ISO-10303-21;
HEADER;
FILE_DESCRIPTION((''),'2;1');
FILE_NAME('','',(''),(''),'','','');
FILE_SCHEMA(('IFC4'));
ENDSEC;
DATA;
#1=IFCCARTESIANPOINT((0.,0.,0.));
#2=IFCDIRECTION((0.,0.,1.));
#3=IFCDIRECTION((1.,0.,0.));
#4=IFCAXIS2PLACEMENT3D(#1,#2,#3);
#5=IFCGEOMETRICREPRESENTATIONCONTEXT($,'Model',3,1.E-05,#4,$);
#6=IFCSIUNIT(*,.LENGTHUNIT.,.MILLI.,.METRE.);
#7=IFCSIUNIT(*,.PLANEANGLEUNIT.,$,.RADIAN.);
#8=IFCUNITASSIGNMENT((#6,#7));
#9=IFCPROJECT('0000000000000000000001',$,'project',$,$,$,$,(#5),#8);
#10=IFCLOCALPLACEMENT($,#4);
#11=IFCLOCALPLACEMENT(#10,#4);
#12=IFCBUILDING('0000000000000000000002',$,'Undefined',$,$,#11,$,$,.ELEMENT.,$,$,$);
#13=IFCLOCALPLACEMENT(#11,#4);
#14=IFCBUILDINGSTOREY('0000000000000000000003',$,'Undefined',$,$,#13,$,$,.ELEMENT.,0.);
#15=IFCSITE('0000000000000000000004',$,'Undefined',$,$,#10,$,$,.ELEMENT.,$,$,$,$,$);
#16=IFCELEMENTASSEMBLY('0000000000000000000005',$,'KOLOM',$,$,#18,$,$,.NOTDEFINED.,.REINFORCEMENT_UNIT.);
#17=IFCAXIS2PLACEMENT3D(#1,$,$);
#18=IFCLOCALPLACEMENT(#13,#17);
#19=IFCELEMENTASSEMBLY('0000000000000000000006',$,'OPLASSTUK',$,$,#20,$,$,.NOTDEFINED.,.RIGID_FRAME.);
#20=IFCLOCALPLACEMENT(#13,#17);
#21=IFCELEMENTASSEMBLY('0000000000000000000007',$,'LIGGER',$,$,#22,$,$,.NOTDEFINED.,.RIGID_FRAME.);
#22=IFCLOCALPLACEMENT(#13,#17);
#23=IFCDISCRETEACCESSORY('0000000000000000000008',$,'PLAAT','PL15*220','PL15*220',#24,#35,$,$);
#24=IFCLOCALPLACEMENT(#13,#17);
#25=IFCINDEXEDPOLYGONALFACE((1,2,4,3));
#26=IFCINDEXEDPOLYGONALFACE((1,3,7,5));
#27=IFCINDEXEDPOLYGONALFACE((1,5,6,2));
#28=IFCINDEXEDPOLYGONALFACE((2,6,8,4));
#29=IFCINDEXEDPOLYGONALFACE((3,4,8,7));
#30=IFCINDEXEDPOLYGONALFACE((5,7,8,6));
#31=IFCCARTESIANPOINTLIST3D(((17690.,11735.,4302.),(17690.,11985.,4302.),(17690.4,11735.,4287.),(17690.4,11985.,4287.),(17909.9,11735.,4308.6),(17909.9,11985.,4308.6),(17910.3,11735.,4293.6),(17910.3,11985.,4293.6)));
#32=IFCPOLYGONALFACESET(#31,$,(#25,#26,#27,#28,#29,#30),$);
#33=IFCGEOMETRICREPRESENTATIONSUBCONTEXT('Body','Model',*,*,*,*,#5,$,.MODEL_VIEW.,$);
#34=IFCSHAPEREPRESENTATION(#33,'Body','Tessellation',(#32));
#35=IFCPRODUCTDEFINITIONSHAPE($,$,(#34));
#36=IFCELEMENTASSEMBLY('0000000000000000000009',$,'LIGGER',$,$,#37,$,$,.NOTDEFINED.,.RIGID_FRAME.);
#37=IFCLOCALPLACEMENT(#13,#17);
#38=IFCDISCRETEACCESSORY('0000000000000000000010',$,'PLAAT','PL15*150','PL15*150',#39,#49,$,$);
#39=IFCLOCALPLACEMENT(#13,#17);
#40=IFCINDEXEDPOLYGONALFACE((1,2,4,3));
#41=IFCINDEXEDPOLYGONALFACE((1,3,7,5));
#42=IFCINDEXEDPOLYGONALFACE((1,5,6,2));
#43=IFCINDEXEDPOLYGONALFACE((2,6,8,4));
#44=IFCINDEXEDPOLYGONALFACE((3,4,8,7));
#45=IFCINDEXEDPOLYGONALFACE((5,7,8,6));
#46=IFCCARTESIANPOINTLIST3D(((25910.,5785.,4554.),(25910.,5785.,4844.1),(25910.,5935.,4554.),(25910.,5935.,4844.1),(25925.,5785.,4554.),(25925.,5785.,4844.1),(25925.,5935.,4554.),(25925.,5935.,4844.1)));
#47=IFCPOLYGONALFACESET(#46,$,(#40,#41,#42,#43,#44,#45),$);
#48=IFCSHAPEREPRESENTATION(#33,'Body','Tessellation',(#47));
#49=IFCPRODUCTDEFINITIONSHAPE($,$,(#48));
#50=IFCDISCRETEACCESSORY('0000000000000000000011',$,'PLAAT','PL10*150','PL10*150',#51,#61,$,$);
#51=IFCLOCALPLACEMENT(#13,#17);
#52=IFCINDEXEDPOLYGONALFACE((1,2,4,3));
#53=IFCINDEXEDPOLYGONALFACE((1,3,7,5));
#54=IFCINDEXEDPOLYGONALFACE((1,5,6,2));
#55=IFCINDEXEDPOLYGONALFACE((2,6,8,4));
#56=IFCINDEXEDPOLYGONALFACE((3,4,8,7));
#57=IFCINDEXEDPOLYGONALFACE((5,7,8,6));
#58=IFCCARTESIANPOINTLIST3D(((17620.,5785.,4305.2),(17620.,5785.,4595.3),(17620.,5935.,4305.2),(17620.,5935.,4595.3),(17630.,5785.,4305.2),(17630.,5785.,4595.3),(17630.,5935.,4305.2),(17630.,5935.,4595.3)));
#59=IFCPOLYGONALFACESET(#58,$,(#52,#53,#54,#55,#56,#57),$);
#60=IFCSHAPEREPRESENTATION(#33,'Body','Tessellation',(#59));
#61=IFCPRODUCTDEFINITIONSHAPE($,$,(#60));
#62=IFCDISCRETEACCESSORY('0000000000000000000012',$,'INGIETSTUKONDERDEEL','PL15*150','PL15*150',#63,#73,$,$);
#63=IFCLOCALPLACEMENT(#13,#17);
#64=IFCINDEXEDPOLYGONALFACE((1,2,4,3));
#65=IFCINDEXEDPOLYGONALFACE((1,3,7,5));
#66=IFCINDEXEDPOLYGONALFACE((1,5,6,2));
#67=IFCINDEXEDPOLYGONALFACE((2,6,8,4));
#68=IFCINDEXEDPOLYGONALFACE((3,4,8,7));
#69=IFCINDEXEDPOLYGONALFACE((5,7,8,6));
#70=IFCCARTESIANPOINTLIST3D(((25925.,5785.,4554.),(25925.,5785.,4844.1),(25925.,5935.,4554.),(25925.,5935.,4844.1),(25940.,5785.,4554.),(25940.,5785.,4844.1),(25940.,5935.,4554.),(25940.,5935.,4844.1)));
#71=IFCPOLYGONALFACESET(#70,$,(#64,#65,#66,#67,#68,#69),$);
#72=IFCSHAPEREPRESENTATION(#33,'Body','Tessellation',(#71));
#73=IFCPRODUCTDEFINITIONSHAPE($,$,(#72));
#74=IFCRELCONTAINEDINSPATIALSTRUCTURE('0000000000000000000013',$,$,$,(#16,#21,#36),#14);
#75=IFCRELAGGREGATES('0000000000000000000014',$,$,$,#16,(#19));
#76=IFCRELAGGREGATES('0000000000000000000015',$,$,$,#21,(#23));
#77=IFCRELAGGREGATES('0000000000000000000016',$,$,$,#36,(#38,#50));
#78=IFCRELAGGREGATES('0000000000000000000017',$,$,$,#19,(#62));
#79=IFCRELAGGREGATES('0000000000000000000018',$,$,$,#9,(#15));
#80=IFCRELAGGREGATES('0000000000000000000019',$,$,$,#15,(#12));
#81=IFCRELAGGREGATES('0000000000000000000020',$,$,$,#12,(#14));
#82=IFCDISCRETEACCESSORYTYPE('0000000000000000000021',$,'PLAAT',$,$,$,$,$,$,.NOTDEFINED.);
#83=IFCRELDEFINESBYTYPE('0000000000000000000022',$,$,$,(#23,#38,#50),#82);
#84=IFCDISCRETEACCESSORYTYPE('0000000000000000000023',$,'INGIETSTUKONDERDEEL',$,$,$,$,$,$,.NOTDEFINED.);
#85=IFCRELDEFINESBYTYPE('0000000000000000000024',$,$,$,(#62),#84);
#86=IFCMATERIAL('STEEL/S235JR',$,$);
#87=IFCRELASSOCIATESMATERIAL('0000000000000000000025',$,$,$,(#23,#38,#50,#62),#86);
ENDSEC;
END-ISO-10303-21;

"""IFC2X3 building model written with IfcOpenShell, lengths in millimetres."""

from ifc_helpers import new_model, si_unit, frame, frame_2d, origin_with_axes, place, context, subcontext, project, spatial, rectangle, extrude, material, type_object, element, aggregate, save


model = new_model("IFC2X3")

# Units and contexts
model_context = context("Model", 3, precision=1e-05, world=origin_with_axes())
body_context = subcontext(model_context, "Body", "Model", "MODEL_VIEW")
ifc_project = project(units=[si_unit("LENGTHUNIT", "METRE", prefix="MILLI"), si_unit("PLANEANGLEUNIT", "RADIAN")], contexts=[model_context])

# Site, building, storey
site_placement = place(None, origin_with_axes())
site = spatial("IfcSite", under=ifc_project, at=site_placement, Name="Undefined", CompositionType="ELEMENT")
building_placement = place(site_placement, origin_with_axes())
building = spatial("IfcBuilding", under=site, at=building_placement, Name="Undefined", CompositionType="ELEMENT")
storey_placement = place(building_placement, origin_with_axes())
storey = spatial("IfcBuildingStorey", under=building, at=storey_placement, Name="Undefined", CompositionType="ELEMENT", Elevation=0.0)

# Shared definitions
ifc_material_1 = material(Name="STEEL/S235JR")

# Element assemblies
assembly_1_placement = place(storey_placement, origin_with_axes())
assembly_1 = element("IfcElementAssembly", 1, at=assembly_1_placement, inside=storey, Name="KOLOM", AssemblyPlace="NOTDEFINED", PredefinedType="REINFORCEMENT_UNIT")
assembly_2_placement = place(assembly_1_placement, origin_with_axes())
assembly_2 = element("IfcElementAssembly", 2, at=assembly_2_placement, Name="OPLASSTUK", AssemblyPlace="NOTDEFINED", PredefinedType="RIGID_FRAME")
aggregate(assembly_1, [assembly_2])

# Element assembly, discrete accessory
assembly_3_placement = place(storey_placement, origin_with_axes())
assembly_3 = element("IfcElementAssembly", 3, at=assembly_3_placement, inside=storey, Name="LIGGER", AssemblyPlace="NOTDEFINED", PredefinedType="RIGID_FRAME")
discrete_accessory_type_1 = type_object("IfcDiscreteAccessoryType", Name="PLAAT")
discrete_accessory_1_placement = place(assembly_3_placement, frame((17800.1, 11735.0, 4297.8), z_axis=(-0.99955, 0.0, -0.029987), x_axis=(0.0, 1.0, 0.0)))
discrete_accessory_1 = element("IfcDiscreteAccessory", 4, at=discrete_accessory_1_placement, type_object=discrete_accessory_type_1, material=ifc_material_1, Name="PLAAT", Description="PL15*220", ObjectType="PL15*220", context=body_context, shape_type="SweptSolid", body=[
    extrude(rectangle(XDim=15.0, YDim=220.0, at=frame_2d((0.0, 0.0), x_axis=(1.0, 0.0))), frame((250.0, 0.0, 0.0), z_axis=(-1.0, 0.0, 0.0), x_axis=(0.0, -1.0, 0.0)), (0.0, 0.0, 1.0), 250.0),
])
aggregate(assembly_3, [discrete_accessory_1])

# Element assembly, discrete accessories
assembly_4_placement = place(storey_placement, origin_with_axes())
assembly_4 = element("IfcElementAssembly", 5, at=assembly_4_placement, inside=storey, Name="LIGGER", AssemblyPlace="NOTDEFINED", PredefinedType="RIGID_FRAME")
discrete_accessory_2_placement = place(assembly_4_placement, frame((25917.5, 5860.0, 4844.1), z_axis=(0.0, -1.0, 0.0), x_axis=(0.0, 0.0, -1.0)))
discrete_accessory_2 = element("IfcDiscreteAccessory", 6, at=discrete_accessory_2_placement, type_object=discrete_accessory_type_1, material=ifc_material_1, Name="PLAAT", Description="PL15*150", ObjectType="PL15*150", context=body_context, shape_type="SweptSolid", body=[
    extrude(rectangle(XDim=15.0, YDim=150.0, at=frame_2d((0.0, 0.0), x_axis=(1.0, 0.0))), frame((290.1, 0.0, 0.0), z_axis=(-1.0, 0.0, 0.0), x_axis=(0.0, -1.0, 0.0)), (0.0, 0.0, 1.0), 290.1),
])
discrete_accessory_3_placement = place(assembly_4_placement, frame((17625.0, 5860.0, 4305.2), z_axis=(0.0, -1.0, 0.0), x_axis=(0.0, 0.0, 1.0)))
discrete_accessory_3 = element("IfcDiscreteAccessory", 7, at=discrete_accessory_3_placement, type_object=discrete_accessory_type_1, material=ifc_material_1, Name="PLAAT", Description="PL10*150", ObjectType="PL10*150", context=body_context, shape_type="SweptSolid", body=[
    extrude(rectangle(XDim=10.0, YDim=150.0, at=frame_2d((0.0, 0.0), x_axis=(1.0, 0.0))), frame((290.1, 0.0, 0.0), z_axis=(-1.0, 0.0, 0.0), x_axis=(0.0, -1.0, 0.0)), (0.0, 0.0, 1.0), 290.1),
])
aggregate(assembly_4, [discrete_accessory_2, discrete_accessory_3])

# Discrete accessory
discrete_accessory_type_2 = type_object("IfcDiscreteAccessoryType", Name="INGIETSTUKONDERDEEL")
discrete_accessory_4_placement = place(assembly_2_placement, frame((25932.5, 5860.0, 4844.1), z_axis=(0.0, -1.0, 0.0), x_axis=(0.0, 0.0, -1.0)))
discrete_accessory_4 = element("IfcDiscreteAccessory", 8, at=discrete_accessory_4_placement, type_object=discrete_accessory_type_2, material=ifc_material_1, Name="INGIETSTUKONDERDEEL", Description="PL15*150", ObjectType="PL15*150", context=body_context, shape_type="SweptSolid", body=[
    extrude(rectangle(XDim=15.0, YDim=150.0, at=frame_2d((0.0, 0.0), x_axis=(1.0, 0.0))), frame((290.1, 0.0, 0.0), z_axis=(-1.0, 0.0, 0.0), x_axis=(0.0, -1.0, 0.0)), (0.0, 0.0, 1.0), 290.1),
])
aggregate(assembly_2, [discrete_accessory_4])

save(model, "model.ifc")
